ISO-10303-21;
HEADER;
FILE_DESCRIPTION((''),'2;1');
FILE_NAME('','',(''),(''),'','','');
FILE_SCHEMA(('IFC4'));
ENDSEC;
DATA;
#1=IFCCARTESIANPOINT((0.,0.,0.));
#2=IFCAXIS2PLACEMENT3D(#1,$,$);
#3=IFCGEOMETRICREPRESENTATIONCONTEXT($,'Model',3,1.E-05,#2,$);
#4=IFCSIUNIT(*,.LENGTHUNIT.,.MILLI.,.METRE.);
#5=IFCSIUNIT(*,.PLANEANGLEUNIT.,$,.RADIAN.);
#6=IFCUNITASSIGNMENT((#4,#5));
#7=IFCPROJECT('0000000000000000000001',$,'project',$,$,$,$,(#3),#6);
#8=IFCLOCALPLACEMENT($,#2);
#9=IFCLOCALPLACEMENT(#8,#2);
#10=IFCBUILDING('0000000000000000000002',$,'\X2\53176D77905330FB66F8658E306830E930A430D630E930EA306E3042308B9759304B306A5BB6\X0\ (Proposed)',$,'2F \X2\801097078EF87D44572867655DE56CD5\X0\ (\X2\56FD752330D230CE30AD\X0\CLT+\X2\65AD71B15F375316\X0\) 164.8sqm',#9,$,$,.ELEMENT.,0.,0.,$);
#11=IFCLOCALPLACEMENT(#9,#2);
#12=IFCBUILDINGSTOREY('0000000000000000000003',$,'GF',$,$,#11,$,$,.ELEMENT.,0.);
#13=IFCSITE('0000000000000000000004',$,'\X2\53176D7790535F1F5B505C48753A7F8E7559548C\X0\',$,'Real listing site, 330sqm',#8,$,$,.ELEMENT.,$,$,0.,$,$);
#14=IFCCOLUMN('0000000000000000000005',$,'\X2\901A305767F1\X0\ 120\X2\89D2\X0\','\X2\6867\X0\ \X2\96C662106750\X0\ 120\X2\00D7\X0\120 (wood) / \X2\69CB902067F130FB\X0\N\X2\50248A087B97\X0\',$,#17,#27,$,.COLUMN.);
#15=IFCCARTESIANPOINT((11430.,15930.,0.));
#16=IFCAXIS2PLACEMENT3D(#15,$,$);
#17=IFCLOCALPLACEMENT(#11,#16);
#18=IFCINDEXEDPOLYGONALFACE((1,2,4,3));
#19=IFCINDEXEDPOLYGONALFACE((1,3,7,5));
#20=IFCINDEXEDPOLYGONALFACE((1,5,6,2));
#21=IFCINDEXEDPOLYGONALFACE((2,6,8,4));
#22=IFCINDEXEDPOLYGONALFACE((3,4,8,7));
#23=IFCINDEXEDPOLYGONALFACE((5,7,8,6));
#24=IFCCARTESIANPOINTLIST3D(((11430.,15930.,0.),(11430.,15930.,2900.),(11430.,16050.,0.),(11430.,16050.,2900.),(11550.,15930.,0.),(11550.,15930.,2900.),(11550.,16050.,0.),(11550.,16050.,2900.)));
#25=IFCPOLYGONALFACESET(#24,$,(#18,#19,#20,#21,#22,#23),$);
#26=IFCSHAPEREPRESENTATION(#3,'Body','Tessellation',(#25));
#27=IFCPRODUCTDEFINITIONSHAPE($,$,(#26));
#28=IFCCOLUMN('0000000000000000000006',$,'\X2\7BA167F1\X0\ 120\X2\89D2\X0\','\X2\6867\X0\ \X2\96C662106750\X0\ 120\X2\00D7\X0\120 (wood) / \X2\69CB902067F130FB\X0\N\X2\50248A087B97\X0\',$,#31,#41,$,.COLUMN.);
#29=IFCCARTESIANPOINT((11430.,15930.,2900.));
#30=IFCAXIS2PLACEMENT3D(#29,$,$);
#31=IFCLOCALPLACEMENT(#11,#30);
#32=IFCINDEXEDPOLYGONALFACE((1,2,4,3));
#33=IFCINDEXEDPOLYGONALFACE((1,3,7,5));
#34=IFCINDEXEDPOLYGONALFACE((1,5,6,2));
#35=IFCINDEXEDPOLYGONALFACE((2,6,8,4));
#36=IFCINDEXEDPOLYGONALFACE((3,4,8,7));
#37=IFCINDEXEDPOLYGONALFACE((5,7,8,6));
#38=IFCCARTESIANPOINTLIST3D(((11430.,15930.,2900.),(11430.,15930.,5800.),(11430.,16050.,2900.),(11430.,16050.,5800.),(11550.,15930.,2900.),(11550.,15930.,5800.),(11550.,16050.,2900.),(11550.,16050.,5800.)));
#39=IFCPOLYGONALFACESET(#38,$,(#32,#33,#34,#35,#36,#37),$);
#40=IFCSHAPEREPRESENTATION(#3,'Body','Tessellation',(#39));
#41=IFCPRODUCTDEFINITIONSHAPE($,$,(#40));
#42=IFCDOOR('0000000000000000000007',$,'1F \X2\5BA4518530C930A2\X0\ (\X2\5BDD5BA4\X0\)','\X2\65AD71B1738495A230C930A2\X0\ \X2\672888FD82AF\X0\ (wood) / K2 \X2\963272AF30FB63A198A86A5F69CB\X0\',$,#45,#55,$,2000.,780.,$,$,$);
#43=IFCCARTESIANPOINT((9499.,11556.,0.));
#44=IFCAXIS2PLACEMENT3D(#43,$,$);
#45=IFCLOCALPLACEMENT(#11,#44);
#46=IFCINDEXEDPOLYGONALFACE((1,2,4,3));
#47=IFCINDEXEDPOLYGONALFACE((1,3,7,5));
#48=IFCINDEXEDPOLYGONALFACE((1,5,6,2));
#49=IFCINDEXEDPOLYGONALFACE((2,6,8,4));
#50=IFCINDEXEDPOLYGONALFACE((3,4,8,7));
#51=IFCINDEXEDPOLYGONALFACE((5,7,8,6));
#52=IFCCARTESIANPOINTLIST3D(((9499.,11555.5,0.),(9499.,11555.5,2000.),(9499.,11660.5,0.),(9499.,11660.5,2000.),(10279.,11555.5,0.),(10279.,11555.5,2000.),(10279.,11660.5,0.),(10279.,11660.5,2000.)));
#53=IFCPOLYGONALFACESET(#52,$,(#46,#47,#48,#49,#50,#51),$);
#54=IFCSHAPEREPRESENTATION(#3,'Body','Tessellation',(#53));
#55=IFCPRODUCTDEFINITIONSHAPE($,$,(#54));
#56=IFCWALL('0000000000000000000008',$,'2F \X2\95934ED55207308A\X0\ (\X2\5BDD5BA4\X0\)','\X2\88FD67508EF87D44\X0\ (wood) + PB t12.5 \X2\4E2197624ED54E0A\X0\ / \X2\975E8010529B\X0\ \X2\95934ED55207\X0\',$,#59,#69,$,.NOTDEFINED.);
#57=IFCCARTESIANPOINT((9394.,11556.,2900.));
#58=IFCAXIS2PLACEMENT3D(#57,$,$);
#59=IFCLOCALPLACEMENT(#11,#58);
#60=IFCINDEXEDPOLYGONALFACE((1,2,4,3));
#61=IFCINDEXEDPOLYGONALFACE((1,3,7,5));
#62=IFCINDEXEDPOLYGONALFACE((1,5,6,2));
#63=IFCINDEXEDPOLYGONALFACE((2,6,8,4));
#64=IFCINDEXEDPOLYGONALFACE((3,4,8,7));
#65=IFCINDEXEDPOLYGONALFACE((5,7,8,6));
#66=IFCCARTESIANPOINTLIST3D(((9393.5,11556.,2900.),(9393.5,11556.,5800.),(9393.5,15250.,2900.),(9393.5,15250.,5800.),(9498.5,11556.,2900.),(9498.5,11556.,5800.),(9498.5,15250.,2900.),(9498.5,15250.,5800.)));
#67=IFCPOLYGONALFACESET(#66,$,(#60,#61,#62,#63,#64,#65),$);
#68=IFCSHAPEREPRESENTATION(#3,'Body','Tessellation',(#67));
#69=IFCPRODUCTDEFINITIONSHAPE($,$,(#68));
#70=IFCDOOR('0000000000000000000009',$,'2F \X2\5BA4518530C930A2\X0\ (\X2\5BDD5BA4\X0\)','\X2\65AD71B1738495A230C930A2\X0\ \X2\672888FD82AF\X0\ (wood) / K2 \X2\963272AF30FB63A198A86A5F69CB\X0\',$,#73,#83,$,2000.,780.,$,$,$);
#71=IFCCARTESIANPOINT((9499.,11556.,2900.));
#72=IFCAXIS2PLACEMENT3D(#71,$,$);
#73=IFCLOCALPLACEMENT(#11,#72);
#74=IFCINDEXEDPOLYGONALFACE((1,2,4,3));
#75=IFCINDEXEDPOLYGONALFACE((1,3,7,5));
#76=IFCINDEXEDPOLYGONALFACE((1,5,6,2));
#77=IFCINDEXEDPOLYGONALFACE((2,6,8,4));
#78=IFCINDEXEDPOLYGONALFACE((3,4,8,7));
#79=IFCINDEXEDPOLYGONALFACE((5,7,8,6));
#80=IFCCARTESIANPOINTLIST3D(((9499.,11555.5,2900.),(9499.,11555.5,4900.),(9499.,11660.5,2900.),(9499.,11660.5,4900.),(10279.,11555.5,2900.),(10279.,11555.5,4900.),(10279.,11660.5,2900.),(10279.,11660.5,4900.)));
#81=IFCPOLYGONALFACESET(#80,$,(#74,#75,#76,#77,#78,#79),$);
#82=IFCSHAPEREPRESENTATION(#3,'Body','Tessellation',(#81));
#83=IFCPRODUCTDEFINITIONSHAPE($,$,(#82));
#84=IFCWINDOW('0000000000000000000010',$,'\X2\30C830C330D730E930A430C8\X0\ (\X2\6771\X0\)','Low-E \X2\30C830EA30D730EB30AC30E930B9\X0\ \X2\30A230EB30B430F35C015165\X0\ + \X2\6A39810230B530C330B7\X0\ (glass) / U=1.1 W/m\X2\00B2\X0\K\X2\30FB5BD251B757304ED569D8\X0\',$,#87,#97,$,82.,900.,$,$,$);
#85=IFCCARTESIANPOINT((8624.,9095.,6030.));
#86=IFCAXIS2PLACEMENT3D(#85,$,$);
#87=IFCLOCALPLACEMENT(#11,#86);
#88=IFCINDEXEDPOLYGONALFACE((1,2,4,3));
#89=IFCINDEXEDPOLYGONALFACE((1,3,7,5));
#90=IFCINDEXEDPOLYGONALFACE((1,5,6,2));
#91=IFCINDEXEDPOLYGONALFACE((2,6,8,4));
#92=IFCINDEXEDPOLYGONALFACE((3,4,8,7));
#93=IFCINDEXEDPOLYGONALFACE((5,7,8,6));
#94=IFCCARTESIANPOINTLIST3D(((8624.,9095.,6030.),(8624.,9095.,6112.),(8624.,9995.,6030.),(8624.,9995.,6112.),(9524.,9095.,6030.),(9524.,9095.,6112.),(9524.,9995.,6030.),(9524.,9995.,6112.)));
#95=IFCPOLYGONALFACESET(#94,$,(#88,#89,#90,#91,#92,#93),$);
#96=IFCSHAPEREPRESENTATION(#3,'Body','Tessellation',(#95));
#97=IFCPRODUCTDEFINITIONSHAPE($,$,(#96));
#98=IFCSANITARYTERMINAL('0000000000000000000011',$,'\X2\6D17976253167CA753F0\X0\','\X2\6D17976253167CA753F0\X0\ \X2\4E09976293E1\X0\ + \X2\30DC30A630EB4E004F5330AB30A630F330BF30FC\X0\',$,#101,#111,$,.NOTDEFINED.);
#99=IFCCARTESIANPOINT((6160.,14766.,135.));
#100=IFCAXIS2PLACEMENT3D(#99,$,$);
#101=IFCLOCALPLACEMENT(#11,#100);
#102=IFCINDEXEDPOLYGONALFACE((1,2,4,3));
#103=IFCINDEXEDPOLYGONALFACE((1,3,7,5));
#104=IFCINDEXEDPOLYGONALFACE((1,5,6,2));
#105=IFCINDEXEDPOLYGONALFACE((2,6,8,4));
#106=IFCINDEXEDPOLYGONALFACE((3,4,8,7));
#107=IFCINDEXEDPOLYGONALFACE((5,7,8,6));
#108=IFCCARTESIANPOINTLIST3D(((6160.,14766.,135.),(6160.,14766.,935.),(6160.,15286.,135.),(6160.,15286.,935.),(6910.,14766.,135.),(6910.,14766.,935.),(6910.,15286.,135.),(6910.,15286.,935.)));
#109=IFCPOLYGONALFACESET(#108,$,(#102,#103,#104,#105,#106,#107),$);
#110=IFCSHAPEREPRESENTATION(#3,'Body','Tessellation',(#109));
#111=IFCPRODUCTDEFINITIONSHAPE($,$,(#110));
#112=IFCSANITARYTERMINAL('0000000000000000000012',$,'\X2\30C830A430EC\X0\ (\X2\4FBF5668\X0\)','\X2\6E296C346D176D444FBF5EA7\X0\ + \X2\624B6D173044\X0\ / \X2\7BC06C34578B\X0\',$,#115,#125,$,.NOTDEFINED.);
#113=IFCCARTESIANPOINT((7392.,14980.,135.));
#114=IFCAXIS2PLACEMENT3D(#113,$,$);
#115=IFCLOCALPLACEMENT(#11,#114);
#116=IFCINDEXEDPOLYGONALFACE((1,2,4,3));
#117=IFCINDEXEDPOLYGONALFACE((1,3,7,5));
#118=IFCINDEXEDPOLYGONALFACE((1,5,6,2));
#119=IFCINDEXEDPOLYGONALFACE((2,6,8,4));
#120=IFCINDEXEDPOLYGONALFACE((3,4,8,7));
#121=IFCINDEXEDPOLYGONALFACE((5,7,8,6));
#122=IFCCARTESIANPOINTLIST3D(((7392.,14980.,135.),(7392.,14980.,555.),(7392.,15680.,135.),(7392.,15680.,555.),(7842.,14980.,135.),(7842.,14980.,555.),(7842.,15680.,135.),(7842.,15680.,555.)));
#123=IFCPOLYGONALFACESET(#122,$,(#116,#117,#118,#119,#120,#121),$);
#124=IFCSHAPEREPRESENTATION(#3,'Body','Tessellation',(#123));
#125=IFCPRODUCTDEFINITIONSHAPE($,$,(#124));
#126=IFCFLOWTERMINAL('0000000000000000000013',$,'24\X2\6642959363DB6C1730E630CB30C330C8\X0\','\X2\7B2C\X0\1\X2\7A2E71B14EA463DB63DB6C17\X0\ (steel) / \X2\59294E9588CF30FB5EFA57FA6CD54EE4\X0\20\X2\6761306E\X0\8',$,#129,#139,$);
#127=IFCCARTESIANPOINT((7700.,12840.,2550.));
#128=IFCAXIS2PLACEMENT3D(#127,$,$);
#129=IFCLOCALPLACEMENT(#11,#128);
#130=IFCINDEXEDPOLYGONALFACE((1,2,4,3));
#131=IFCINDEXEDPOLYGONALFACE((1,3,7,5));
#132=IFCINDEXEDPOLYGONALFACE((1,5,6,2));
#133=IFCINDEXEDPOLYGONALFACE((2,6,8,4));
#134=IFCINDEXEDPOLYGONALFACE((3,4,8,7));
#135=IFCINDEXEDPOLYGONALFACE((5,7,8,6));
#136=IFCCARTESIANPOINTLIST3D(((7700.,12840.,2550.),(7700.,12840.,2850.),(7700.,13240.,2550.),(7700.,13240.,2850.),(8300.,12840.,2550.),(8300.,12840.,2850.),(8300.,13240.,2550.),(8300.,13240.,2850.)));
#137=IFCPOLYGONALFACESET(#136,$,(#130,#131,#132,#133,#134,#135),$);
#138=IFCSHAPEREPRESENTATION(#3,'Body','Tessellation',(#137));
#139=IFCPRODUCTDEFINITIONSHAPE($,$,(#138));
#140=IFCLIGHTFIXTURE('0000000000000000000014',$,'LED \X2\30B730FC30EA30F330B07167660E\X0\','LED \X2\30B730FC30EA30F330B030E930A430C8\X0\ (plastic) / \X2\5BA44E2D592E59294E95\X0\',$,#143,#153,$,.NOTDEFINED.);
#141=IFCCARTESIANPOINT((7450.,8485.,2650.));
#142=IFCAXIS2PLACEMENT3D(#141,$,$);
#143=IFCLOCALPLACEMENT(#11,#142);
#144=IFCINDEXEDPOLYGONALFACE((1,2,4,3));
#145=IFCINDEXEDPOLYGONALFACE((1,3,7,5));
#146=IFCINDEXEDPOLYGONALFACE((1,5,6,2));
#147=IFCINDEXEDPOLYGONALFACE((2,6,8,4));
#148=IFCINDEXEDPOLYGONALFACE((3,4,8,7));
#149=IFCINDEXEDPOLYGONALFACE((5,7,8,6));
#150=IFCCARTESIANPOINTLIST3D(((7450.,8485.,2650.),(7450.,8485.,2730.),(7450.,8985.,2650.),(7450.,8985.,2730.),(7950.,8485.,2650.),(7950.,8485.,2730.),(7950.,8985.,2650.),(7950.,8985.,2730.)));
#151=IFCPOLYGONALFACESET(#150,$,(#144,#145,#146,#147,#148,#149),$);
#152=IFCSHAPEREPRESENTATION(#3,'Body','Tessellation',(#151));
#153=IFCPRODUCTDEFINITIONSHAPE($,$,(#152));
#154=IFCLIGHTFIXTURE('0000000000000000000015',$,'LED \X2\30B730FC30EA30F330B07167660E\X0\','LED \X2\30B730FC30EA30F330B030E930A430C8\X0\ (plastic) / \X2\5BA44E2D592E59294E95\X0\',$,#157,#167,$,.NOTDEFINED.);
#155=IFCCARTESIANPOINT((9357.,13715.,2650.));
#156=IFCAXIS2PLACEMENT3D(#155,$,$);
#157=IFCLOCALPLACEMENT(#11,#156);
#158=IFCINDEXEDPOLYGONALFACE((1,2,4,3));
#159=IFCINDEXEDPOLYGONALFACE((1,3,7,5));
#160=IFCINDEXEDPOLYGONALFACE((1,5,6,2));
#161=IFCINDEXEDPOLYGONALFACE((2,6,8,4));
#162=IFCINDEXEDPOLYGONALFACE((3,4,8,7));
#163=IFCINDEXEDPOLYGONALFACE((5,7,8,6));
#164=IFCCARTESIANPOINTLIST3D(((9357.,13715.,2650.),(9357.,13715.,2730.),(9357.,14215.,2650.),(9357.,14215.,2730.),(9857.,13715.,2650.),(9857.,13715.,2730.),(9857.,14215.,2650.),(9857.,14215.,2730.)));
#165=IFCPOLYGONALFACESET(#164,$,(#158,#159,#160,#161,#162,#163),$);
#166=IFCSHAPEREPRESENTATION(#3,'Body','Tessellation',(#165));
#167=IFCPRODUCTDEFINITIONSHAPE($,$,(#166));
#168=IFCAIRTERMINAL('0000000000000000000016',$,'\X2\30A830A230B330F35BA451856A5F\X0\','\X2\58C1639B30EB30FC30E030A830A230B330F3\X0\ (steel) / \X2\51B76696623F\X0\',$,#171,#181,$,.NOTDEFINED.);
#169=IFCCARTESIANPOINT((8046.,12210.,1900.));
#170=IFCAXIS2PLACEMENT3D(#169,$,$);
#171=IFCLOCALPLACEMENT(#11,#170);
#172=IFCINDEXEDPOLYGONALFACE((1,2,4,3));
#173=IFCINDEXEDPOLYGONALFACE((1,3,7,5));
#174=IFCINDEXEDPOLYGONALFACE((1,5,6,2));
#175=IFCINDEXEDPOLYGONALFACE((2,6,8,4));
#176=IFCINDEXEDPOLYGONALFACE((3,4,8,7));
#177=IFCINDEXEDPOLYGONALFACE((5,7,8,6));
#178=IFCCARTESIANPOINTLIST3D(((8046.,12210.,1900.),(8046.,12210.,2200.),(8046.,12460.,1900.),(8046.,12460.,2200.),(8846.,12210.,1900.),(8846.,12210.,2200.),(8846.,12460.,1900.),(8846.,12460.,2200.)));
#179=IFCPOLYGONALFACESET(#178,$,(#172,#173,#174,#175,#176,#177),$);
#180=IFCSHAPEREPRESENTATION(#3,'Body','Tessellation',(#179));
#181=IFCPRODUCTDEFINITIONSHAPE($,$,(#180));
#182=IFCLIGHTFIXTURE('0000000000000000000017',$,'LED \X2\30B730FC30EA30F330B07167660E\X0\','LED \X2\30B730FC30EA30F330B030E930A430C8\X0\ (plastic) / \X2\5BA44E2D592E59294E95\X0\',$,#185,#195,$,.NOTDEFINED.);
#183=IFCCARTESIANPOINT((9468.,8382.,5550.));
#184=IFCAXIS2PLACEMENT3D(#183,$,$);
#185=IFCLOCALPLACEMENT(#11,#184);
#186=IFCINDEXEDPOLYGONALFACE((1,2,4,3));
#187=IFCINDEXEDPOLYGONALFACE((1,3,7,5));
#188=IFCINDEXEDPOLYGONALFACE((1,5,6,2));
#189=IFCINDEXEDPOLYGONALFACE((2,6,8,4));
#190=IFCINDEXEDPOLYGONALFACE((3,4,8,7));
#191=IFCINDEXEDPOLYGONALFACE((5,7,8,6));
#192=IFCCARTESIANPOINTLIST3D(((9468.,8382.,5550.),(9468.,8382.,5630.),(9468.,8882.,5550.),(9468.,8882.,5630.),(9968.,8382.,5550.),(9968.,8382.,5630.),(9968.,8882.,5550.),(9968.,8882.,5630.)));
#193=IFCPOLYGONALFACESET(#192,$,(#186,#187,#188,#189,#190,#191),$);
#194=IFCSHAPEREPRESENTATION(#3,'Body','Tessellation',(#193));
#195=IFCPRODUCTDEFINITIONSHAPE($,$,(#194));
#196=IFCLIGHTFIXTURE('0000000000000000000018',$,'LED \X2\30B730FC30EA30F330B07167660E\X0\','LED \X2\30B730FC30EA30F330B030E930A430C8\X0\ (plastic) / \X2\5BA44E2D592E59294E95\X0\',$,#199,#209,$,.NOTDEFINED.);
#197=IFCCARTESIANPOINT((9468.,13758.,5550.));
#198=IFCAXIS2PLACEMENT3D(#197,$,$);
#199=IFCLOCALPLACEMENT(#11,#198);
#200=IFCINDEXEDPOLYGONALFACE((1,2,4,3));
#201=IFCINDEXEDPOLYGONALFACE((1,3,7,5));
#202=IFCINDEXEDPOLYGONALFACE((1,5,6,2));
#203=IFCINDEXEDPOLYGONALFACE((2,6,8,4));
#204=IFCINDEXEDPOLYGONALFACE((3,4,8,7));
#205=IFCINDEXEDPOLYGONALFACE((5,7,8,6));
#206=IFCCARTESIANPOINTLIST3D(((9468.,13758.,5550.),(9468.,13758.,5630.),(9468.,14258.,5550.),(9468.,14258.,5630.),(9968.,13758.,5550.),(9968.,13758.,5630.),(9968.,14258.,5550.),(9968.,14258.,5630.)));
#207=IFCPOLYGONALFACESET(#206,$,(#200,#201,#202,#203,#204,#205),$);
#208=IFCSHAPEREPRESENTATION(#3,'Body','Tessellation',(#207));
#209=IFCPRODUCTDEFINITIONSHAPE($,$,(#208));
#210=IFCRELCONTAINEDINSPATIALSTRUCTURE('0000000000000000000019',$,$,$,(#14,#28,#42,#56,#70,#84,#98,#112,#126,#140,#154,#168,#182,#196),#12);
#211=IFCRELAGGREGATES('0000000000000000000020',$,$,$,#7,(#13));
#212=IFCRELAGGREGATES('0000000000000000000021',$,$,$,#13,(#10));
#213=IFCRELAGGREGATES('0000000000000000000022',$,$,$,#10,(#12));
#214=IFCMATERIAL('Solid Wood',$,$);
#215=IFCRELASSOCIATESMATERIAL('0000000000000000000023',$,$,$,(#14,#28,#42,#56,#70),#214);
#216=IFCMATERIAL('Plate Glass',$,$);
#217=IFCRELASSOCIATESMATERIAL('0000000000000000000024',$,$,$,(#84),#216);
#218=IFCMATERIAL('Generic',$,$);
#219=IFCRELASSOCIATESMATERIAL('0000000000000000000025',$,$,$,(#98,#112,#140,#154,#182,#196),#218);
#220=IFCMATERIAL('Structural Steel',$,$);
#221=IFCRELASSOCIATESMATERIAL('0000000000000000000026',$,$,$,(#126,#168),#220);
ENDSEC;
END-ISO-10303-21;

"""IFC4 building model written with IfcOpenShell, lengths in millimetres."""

from ifc_helpers import new_model, si_unit, frame, frame_2d, origin, place, context, project, spatial, rectangle, extrude, material, element, save


model = new_model("IFC4")

# Units and contexts
model_context = context("Model", 3, precision=1e-05, world=origin())
ifc_project = project(units=[si_unit("LENGTHUNIT", "METRE", prefix="MILLI"), si_unit("PLANEANGLEUNIT", "RADIAN")], contexts=[model_context])

# Site, building, storey
site_placement = place(None, origin())
site = spatial("IfcSite", under=ifc_project, at=site_placement, Name="北海道弟子屈町美留和", ObjectType="Real listing site, 330sqm", CompositionType="ELEMENT", RefElevation=0.0)
building_placement = place(site_placement, origin())
building = spatial("IfcBuilding", under=site, at=building_placement, Name="北海道・書斎とライブラリのある静かな家 (Proposed)", ObjectType="2F 耐震軸組在来工法 (国産ヒノキCLT+断熱強化) 164.8sqm", CompositionType="ELEMENT", ElevationOfRefHeight=0.0, ElevationOfTerrain=0.0)
storey_placement = place(building_placement, origin())
storey = spatial("IfcBuildingStorey", under=building, at=storey_placement, Name="GF", CompositionType="ELEMENT", Elevation=0.0)

# Columns
ifc_material_1 = material(Name="Solid Wood")
column_1_placement = place(storey_placement, frame((11430.0, 15930.0, 0.0)))
element("IfcColumn", 1, at=column_1_placement, inside=storey, material=ifc_material_1, Name="通し柱 120角", Description="桧 集成材 120×120 (wood) / 構造柱・N値計算", PredefinedType="COLUMN", context=model_context, shape_type="SweptSolid", body=[
    extrude(rectangle(XDim=120.0, YDim=120.0, at=frame_2d((60.0, 60.0))), frame((11430.0, 15930.0, 0.0)), (0.0, 0.0, 1.0), 2900.0),
])
column_2_placement = place(storey_placement, frame((11430.0, 15930.0, 2900.0)))
element("IfcColumn", 2, at=column_2_placement, inside=storey, material=ifc_material_1, Name="管柱 120角", Description="桧 集成材 120×120 (wood) / 構造柱・N値計算", PredefinedType="COLUMN", context=model_context, shape_type="SweptSolid", body=[
    extrude(rectangle(XDim=120.0, YDim=120.0, at=frame_2d((60.0, 60.0))), frame((11430.0, 15930.0, 2900.0)), (0.0, 0.0, 1.0), 2900.0),
])

# Door
door_1_placement = place(storey_placement, frame((9499.0, 11556.0, 0.0)))
element("IfcDoor", 3, at=door_1_placement, inside=storey, material=ifc_material_1, Name="1F 室内ドア (寝室)", Description="断熱玄関ドア 木製芯 (wood) / K2 防犯・採風機構", OverallHeight=2000.0, OverallWidth=780.0, context=model_context, shape_type="SweptSolid", body=[
    extrude(rectangle(XDim=780.0, YDim=105.0, at=frame_2d((390.0, 52.0))), frame((9499.0, 11556.0, 0.0)), (0.0, 0.0, 1.0), 2000.0),
])

# Wall
wall_1_placement = place(storey_placement, frame((9394.0, 11556.0, 2900.0)))
element("IfcWall", 4, at=wall_1_placement, inside=storey, material=ifc_material_1, Name="2F 間仕切り (寝室)", Description="製材軸組 (wood) + PB t12.5 両面仕上 / 非耐力 間仕切", PredefinedType="NOTDEFINED", context=model_context, shape_type="SweptSolid", body=[
    extrude(rectangle(XDim=105.0, YDim=3694.0, at=frame_2d((52.0, 1847.0))), frame((9394.0, 11556.0, 2900.0)), (0.0, 0.0, 1.0), 2900.0),
])

# Door
door_2_placement = place(storey_placement, frame((9499.0, 11556.0, 2900.0)))
element("IfcDoor", 5, at=door_2_placement, inside=storey, material=ifc_material_1, Name="2F 室内ドア (寝室)", Description="断熱玄関ドア 木製芯 (wood) / K2 防犯・採風機構", OverallHeight=2000.0, OverallWidth=780.0, context=model_context, shape_type="SweptSolid", body=[
    extrude(rectangle(XDim=780.0, YDim=105.0, at=frame_2d((390.0, 52.0))), frame((9499.0, 11556.0, 2900.0)), (0.0, 0.0, 1.0), 2000.0),
])

# Window
ifc_material_2 = material(Name="Plate Glass")
window_placement = place(storey_placement, frame((8624.0, 9095.0, 6030.0)))
element("IfcWindow", 6, at=window_placement, inside=storey, material=ifc_material_2, Name="トップライト (東)", Description="Low-E トリプルガラス アルゴン封入 + 樹脂サッシ (glass) / U=1.1 W/m²K・寒冷地仕様", OverallHeight=82.0, OverallWidth=900.0, context=model_context, shape_type="SweptSolid", body=[
    extrude(rectangle(XDim=900.0, YDim=900.0, at=frame_2d((450.0, 450.0))), frame((8624.0, 9095.0, 6030.0)), (0.0, 0.0, 1.0), 82.0),
])

# Sanitary terminals
ifc_material_3 = material(Name="Generic")
sanitary_terminal_1_placement = place(storey_placement, frame((6160.0, 14766.0, 135.0)))
element("IfcSanitaryTerminal", 7, at=sanitary_terminal_1_placement, inside=storey, material=ifc_material_3, Name="洗面化粧台", Description="洗面化粧台 三面鏡 + ボウル一体カウンター", PredefinedType="NOTDEFINED", context=model_context, shape_type="SweptSolid", body=[
    extrude(rectangle(XDim=750.0, YDim=520.0, at=frame_2d((375.0, 260.0))), frame((6160.0, 14766.0, 135.0)), (0.0, 0.0, 1.0), 800.0),
])
sanitary_terminal_2_placement = place(storey_placement, frame((7392.0, 14980.0, 135.0)))
element("IfcSanitaryTerminal", 8, at=sanitary_terminal_2_placement, inside=storey, material=ifc_material_3, Name="トイレ (便器)", Description="温水洗浄便座 + 手洗い / 節水型", PredefinedType="NOTDEFINED", context=model_context, shape_type="SweptSolid", body=[
    extrude(rectangle(XDim=450.0, YDim=700.0, at=frame_2d((225.0, 350.0))), frame((7392.0, 14980.0, 135.0)), (0.0, 0.0, 1.0), 420.0),
])

# Flow terminal
ifc_material_4 = material(Name="Structural Steel")
flow_terminal_placement = place(storey_placement, frame((7700.0, 12840.0, 2550.0)))
element("IfcFlowTerminal", 9, at=flow_terminal_placement, inside=storey, material=ifc_material_4, Name="24時間換気ユニット", Description="第1種熱交換換気 (steel) / 天井裏・建基法令20条の8", context=model_context, shape_type="SweptSolid", body=[
    extrude(rectangle(XDim=600.0, YDim=400.0, at=frame_2d((300.0, 200.0))), frame((7700.0, 12840.0, 2550.0)), (0.0, 0.0, 1.0), 300.0),
])

# Light fixtures
light_fixture_1_placement = place(storey_placement, frame((7450.0, 8485.0, 2650.0)))
element("IfcLightFixture", 10, at=light_fixture_1_placement, inside=storey, material=ifc_material_3, Name="LED シーリング照明", Description="LED シーリングライト (plastic) / 室中央天井", PredefinedType="NOTDEFINED", context=model_context, shape_type="SweptSolid", body=[
    extrude(rectangle(XDim=500.0, YDim=500.0, at=frame_2d((250.0, 250.0))), frame((7450.0, 8485.0, 2650.0)), (0.0, 0.0, 1.0), 80.0),
])
light_fixture_2_placement = place(storey_placement, frame((9357.0, 13715.0, 2650.0)))
element("IfcLightFixture", 11, at=light_fixture_2_placement, inside=storey, material=ifc_material_3, Name="LED シーリング照明", Description="LED シーリングライト (plastic) / 室中央天井", PredefinedType="NOTDEFINED", context=model_context, shape_type="SweptSolid", body=[
    extrude(rectangle(XDim=500.0, YDim=500.0, at=frame_2d((250.0, 250.0))), frame((9357.0, 13715.0, 2650.0)), (0.0, 0.0, 1.0), 80.0),
])

# Air terminal
air_terminal_placement = place(storey_placement, frame((8046.0, 12210.0, 1900.0)))
element("IfcAirTerminal", 12, at=air_terminal_placement, inside=storey, material=ifc_material_4, Name="エアコン室内機", Description="壁掛ルームエアコン (steel) / 冷暖房", PredefinedType="NOTDEFINED", context=model_context, shape_type="SweptSolid", body=[
    extrude(rectangle(XDim=800.0, YDim=250.0, at=frame_2d((400.0, 125.0))), frame((8046.0, 12210.0, 1900.0)), (0.0, 0.0, 1.0), 300.0),
])

# Light fixtures
light_fixture_3_placement = place(storey_placement, frame((9468.0, 8382.0, 5550.0)))
element("IfcLightFixture", 13, at=light_fixture_3_placement, inside=storey, material=ifc_material_3, Name="LED シーリング照明", Description="LED シーリングライト (plastic) / 室中央天井", PredefinedType="NOTDEFINED", context=model_context, shape_type="SweptSolid", body=[
    extrude(rectangle(XDim=500.0, YDim=500.0, at=frame_2d((250.0, 250.0))), frame((9468.0, 8382.0, 5550.0)), (0.0, 0.0, 1.0), 80.0),
])
light_fixture_4_placement = place(storey_placement, frame((9468.0, 13758.0, 5550.0)))
element("IfcLightFixture", 14, at=light_fixture_4_placement, inside=storey, material=ifc_material_3, Name="LED シーリング照明", Description="LED シーリングライト (plastic) / 室中央天井", PredefinedType="NOTDEFINED", context=model_context, shape_type="SweptSolid", body=[
    extrude(rectangle(XDim=500.0, YDim=500.0, at=frame_2d((250.0, 250.0))), frame((9468.0, 13758.0, 5550.0)), (0.0, 0.0, 1.0), 80.0),
])

save(model, "model.ifc")
